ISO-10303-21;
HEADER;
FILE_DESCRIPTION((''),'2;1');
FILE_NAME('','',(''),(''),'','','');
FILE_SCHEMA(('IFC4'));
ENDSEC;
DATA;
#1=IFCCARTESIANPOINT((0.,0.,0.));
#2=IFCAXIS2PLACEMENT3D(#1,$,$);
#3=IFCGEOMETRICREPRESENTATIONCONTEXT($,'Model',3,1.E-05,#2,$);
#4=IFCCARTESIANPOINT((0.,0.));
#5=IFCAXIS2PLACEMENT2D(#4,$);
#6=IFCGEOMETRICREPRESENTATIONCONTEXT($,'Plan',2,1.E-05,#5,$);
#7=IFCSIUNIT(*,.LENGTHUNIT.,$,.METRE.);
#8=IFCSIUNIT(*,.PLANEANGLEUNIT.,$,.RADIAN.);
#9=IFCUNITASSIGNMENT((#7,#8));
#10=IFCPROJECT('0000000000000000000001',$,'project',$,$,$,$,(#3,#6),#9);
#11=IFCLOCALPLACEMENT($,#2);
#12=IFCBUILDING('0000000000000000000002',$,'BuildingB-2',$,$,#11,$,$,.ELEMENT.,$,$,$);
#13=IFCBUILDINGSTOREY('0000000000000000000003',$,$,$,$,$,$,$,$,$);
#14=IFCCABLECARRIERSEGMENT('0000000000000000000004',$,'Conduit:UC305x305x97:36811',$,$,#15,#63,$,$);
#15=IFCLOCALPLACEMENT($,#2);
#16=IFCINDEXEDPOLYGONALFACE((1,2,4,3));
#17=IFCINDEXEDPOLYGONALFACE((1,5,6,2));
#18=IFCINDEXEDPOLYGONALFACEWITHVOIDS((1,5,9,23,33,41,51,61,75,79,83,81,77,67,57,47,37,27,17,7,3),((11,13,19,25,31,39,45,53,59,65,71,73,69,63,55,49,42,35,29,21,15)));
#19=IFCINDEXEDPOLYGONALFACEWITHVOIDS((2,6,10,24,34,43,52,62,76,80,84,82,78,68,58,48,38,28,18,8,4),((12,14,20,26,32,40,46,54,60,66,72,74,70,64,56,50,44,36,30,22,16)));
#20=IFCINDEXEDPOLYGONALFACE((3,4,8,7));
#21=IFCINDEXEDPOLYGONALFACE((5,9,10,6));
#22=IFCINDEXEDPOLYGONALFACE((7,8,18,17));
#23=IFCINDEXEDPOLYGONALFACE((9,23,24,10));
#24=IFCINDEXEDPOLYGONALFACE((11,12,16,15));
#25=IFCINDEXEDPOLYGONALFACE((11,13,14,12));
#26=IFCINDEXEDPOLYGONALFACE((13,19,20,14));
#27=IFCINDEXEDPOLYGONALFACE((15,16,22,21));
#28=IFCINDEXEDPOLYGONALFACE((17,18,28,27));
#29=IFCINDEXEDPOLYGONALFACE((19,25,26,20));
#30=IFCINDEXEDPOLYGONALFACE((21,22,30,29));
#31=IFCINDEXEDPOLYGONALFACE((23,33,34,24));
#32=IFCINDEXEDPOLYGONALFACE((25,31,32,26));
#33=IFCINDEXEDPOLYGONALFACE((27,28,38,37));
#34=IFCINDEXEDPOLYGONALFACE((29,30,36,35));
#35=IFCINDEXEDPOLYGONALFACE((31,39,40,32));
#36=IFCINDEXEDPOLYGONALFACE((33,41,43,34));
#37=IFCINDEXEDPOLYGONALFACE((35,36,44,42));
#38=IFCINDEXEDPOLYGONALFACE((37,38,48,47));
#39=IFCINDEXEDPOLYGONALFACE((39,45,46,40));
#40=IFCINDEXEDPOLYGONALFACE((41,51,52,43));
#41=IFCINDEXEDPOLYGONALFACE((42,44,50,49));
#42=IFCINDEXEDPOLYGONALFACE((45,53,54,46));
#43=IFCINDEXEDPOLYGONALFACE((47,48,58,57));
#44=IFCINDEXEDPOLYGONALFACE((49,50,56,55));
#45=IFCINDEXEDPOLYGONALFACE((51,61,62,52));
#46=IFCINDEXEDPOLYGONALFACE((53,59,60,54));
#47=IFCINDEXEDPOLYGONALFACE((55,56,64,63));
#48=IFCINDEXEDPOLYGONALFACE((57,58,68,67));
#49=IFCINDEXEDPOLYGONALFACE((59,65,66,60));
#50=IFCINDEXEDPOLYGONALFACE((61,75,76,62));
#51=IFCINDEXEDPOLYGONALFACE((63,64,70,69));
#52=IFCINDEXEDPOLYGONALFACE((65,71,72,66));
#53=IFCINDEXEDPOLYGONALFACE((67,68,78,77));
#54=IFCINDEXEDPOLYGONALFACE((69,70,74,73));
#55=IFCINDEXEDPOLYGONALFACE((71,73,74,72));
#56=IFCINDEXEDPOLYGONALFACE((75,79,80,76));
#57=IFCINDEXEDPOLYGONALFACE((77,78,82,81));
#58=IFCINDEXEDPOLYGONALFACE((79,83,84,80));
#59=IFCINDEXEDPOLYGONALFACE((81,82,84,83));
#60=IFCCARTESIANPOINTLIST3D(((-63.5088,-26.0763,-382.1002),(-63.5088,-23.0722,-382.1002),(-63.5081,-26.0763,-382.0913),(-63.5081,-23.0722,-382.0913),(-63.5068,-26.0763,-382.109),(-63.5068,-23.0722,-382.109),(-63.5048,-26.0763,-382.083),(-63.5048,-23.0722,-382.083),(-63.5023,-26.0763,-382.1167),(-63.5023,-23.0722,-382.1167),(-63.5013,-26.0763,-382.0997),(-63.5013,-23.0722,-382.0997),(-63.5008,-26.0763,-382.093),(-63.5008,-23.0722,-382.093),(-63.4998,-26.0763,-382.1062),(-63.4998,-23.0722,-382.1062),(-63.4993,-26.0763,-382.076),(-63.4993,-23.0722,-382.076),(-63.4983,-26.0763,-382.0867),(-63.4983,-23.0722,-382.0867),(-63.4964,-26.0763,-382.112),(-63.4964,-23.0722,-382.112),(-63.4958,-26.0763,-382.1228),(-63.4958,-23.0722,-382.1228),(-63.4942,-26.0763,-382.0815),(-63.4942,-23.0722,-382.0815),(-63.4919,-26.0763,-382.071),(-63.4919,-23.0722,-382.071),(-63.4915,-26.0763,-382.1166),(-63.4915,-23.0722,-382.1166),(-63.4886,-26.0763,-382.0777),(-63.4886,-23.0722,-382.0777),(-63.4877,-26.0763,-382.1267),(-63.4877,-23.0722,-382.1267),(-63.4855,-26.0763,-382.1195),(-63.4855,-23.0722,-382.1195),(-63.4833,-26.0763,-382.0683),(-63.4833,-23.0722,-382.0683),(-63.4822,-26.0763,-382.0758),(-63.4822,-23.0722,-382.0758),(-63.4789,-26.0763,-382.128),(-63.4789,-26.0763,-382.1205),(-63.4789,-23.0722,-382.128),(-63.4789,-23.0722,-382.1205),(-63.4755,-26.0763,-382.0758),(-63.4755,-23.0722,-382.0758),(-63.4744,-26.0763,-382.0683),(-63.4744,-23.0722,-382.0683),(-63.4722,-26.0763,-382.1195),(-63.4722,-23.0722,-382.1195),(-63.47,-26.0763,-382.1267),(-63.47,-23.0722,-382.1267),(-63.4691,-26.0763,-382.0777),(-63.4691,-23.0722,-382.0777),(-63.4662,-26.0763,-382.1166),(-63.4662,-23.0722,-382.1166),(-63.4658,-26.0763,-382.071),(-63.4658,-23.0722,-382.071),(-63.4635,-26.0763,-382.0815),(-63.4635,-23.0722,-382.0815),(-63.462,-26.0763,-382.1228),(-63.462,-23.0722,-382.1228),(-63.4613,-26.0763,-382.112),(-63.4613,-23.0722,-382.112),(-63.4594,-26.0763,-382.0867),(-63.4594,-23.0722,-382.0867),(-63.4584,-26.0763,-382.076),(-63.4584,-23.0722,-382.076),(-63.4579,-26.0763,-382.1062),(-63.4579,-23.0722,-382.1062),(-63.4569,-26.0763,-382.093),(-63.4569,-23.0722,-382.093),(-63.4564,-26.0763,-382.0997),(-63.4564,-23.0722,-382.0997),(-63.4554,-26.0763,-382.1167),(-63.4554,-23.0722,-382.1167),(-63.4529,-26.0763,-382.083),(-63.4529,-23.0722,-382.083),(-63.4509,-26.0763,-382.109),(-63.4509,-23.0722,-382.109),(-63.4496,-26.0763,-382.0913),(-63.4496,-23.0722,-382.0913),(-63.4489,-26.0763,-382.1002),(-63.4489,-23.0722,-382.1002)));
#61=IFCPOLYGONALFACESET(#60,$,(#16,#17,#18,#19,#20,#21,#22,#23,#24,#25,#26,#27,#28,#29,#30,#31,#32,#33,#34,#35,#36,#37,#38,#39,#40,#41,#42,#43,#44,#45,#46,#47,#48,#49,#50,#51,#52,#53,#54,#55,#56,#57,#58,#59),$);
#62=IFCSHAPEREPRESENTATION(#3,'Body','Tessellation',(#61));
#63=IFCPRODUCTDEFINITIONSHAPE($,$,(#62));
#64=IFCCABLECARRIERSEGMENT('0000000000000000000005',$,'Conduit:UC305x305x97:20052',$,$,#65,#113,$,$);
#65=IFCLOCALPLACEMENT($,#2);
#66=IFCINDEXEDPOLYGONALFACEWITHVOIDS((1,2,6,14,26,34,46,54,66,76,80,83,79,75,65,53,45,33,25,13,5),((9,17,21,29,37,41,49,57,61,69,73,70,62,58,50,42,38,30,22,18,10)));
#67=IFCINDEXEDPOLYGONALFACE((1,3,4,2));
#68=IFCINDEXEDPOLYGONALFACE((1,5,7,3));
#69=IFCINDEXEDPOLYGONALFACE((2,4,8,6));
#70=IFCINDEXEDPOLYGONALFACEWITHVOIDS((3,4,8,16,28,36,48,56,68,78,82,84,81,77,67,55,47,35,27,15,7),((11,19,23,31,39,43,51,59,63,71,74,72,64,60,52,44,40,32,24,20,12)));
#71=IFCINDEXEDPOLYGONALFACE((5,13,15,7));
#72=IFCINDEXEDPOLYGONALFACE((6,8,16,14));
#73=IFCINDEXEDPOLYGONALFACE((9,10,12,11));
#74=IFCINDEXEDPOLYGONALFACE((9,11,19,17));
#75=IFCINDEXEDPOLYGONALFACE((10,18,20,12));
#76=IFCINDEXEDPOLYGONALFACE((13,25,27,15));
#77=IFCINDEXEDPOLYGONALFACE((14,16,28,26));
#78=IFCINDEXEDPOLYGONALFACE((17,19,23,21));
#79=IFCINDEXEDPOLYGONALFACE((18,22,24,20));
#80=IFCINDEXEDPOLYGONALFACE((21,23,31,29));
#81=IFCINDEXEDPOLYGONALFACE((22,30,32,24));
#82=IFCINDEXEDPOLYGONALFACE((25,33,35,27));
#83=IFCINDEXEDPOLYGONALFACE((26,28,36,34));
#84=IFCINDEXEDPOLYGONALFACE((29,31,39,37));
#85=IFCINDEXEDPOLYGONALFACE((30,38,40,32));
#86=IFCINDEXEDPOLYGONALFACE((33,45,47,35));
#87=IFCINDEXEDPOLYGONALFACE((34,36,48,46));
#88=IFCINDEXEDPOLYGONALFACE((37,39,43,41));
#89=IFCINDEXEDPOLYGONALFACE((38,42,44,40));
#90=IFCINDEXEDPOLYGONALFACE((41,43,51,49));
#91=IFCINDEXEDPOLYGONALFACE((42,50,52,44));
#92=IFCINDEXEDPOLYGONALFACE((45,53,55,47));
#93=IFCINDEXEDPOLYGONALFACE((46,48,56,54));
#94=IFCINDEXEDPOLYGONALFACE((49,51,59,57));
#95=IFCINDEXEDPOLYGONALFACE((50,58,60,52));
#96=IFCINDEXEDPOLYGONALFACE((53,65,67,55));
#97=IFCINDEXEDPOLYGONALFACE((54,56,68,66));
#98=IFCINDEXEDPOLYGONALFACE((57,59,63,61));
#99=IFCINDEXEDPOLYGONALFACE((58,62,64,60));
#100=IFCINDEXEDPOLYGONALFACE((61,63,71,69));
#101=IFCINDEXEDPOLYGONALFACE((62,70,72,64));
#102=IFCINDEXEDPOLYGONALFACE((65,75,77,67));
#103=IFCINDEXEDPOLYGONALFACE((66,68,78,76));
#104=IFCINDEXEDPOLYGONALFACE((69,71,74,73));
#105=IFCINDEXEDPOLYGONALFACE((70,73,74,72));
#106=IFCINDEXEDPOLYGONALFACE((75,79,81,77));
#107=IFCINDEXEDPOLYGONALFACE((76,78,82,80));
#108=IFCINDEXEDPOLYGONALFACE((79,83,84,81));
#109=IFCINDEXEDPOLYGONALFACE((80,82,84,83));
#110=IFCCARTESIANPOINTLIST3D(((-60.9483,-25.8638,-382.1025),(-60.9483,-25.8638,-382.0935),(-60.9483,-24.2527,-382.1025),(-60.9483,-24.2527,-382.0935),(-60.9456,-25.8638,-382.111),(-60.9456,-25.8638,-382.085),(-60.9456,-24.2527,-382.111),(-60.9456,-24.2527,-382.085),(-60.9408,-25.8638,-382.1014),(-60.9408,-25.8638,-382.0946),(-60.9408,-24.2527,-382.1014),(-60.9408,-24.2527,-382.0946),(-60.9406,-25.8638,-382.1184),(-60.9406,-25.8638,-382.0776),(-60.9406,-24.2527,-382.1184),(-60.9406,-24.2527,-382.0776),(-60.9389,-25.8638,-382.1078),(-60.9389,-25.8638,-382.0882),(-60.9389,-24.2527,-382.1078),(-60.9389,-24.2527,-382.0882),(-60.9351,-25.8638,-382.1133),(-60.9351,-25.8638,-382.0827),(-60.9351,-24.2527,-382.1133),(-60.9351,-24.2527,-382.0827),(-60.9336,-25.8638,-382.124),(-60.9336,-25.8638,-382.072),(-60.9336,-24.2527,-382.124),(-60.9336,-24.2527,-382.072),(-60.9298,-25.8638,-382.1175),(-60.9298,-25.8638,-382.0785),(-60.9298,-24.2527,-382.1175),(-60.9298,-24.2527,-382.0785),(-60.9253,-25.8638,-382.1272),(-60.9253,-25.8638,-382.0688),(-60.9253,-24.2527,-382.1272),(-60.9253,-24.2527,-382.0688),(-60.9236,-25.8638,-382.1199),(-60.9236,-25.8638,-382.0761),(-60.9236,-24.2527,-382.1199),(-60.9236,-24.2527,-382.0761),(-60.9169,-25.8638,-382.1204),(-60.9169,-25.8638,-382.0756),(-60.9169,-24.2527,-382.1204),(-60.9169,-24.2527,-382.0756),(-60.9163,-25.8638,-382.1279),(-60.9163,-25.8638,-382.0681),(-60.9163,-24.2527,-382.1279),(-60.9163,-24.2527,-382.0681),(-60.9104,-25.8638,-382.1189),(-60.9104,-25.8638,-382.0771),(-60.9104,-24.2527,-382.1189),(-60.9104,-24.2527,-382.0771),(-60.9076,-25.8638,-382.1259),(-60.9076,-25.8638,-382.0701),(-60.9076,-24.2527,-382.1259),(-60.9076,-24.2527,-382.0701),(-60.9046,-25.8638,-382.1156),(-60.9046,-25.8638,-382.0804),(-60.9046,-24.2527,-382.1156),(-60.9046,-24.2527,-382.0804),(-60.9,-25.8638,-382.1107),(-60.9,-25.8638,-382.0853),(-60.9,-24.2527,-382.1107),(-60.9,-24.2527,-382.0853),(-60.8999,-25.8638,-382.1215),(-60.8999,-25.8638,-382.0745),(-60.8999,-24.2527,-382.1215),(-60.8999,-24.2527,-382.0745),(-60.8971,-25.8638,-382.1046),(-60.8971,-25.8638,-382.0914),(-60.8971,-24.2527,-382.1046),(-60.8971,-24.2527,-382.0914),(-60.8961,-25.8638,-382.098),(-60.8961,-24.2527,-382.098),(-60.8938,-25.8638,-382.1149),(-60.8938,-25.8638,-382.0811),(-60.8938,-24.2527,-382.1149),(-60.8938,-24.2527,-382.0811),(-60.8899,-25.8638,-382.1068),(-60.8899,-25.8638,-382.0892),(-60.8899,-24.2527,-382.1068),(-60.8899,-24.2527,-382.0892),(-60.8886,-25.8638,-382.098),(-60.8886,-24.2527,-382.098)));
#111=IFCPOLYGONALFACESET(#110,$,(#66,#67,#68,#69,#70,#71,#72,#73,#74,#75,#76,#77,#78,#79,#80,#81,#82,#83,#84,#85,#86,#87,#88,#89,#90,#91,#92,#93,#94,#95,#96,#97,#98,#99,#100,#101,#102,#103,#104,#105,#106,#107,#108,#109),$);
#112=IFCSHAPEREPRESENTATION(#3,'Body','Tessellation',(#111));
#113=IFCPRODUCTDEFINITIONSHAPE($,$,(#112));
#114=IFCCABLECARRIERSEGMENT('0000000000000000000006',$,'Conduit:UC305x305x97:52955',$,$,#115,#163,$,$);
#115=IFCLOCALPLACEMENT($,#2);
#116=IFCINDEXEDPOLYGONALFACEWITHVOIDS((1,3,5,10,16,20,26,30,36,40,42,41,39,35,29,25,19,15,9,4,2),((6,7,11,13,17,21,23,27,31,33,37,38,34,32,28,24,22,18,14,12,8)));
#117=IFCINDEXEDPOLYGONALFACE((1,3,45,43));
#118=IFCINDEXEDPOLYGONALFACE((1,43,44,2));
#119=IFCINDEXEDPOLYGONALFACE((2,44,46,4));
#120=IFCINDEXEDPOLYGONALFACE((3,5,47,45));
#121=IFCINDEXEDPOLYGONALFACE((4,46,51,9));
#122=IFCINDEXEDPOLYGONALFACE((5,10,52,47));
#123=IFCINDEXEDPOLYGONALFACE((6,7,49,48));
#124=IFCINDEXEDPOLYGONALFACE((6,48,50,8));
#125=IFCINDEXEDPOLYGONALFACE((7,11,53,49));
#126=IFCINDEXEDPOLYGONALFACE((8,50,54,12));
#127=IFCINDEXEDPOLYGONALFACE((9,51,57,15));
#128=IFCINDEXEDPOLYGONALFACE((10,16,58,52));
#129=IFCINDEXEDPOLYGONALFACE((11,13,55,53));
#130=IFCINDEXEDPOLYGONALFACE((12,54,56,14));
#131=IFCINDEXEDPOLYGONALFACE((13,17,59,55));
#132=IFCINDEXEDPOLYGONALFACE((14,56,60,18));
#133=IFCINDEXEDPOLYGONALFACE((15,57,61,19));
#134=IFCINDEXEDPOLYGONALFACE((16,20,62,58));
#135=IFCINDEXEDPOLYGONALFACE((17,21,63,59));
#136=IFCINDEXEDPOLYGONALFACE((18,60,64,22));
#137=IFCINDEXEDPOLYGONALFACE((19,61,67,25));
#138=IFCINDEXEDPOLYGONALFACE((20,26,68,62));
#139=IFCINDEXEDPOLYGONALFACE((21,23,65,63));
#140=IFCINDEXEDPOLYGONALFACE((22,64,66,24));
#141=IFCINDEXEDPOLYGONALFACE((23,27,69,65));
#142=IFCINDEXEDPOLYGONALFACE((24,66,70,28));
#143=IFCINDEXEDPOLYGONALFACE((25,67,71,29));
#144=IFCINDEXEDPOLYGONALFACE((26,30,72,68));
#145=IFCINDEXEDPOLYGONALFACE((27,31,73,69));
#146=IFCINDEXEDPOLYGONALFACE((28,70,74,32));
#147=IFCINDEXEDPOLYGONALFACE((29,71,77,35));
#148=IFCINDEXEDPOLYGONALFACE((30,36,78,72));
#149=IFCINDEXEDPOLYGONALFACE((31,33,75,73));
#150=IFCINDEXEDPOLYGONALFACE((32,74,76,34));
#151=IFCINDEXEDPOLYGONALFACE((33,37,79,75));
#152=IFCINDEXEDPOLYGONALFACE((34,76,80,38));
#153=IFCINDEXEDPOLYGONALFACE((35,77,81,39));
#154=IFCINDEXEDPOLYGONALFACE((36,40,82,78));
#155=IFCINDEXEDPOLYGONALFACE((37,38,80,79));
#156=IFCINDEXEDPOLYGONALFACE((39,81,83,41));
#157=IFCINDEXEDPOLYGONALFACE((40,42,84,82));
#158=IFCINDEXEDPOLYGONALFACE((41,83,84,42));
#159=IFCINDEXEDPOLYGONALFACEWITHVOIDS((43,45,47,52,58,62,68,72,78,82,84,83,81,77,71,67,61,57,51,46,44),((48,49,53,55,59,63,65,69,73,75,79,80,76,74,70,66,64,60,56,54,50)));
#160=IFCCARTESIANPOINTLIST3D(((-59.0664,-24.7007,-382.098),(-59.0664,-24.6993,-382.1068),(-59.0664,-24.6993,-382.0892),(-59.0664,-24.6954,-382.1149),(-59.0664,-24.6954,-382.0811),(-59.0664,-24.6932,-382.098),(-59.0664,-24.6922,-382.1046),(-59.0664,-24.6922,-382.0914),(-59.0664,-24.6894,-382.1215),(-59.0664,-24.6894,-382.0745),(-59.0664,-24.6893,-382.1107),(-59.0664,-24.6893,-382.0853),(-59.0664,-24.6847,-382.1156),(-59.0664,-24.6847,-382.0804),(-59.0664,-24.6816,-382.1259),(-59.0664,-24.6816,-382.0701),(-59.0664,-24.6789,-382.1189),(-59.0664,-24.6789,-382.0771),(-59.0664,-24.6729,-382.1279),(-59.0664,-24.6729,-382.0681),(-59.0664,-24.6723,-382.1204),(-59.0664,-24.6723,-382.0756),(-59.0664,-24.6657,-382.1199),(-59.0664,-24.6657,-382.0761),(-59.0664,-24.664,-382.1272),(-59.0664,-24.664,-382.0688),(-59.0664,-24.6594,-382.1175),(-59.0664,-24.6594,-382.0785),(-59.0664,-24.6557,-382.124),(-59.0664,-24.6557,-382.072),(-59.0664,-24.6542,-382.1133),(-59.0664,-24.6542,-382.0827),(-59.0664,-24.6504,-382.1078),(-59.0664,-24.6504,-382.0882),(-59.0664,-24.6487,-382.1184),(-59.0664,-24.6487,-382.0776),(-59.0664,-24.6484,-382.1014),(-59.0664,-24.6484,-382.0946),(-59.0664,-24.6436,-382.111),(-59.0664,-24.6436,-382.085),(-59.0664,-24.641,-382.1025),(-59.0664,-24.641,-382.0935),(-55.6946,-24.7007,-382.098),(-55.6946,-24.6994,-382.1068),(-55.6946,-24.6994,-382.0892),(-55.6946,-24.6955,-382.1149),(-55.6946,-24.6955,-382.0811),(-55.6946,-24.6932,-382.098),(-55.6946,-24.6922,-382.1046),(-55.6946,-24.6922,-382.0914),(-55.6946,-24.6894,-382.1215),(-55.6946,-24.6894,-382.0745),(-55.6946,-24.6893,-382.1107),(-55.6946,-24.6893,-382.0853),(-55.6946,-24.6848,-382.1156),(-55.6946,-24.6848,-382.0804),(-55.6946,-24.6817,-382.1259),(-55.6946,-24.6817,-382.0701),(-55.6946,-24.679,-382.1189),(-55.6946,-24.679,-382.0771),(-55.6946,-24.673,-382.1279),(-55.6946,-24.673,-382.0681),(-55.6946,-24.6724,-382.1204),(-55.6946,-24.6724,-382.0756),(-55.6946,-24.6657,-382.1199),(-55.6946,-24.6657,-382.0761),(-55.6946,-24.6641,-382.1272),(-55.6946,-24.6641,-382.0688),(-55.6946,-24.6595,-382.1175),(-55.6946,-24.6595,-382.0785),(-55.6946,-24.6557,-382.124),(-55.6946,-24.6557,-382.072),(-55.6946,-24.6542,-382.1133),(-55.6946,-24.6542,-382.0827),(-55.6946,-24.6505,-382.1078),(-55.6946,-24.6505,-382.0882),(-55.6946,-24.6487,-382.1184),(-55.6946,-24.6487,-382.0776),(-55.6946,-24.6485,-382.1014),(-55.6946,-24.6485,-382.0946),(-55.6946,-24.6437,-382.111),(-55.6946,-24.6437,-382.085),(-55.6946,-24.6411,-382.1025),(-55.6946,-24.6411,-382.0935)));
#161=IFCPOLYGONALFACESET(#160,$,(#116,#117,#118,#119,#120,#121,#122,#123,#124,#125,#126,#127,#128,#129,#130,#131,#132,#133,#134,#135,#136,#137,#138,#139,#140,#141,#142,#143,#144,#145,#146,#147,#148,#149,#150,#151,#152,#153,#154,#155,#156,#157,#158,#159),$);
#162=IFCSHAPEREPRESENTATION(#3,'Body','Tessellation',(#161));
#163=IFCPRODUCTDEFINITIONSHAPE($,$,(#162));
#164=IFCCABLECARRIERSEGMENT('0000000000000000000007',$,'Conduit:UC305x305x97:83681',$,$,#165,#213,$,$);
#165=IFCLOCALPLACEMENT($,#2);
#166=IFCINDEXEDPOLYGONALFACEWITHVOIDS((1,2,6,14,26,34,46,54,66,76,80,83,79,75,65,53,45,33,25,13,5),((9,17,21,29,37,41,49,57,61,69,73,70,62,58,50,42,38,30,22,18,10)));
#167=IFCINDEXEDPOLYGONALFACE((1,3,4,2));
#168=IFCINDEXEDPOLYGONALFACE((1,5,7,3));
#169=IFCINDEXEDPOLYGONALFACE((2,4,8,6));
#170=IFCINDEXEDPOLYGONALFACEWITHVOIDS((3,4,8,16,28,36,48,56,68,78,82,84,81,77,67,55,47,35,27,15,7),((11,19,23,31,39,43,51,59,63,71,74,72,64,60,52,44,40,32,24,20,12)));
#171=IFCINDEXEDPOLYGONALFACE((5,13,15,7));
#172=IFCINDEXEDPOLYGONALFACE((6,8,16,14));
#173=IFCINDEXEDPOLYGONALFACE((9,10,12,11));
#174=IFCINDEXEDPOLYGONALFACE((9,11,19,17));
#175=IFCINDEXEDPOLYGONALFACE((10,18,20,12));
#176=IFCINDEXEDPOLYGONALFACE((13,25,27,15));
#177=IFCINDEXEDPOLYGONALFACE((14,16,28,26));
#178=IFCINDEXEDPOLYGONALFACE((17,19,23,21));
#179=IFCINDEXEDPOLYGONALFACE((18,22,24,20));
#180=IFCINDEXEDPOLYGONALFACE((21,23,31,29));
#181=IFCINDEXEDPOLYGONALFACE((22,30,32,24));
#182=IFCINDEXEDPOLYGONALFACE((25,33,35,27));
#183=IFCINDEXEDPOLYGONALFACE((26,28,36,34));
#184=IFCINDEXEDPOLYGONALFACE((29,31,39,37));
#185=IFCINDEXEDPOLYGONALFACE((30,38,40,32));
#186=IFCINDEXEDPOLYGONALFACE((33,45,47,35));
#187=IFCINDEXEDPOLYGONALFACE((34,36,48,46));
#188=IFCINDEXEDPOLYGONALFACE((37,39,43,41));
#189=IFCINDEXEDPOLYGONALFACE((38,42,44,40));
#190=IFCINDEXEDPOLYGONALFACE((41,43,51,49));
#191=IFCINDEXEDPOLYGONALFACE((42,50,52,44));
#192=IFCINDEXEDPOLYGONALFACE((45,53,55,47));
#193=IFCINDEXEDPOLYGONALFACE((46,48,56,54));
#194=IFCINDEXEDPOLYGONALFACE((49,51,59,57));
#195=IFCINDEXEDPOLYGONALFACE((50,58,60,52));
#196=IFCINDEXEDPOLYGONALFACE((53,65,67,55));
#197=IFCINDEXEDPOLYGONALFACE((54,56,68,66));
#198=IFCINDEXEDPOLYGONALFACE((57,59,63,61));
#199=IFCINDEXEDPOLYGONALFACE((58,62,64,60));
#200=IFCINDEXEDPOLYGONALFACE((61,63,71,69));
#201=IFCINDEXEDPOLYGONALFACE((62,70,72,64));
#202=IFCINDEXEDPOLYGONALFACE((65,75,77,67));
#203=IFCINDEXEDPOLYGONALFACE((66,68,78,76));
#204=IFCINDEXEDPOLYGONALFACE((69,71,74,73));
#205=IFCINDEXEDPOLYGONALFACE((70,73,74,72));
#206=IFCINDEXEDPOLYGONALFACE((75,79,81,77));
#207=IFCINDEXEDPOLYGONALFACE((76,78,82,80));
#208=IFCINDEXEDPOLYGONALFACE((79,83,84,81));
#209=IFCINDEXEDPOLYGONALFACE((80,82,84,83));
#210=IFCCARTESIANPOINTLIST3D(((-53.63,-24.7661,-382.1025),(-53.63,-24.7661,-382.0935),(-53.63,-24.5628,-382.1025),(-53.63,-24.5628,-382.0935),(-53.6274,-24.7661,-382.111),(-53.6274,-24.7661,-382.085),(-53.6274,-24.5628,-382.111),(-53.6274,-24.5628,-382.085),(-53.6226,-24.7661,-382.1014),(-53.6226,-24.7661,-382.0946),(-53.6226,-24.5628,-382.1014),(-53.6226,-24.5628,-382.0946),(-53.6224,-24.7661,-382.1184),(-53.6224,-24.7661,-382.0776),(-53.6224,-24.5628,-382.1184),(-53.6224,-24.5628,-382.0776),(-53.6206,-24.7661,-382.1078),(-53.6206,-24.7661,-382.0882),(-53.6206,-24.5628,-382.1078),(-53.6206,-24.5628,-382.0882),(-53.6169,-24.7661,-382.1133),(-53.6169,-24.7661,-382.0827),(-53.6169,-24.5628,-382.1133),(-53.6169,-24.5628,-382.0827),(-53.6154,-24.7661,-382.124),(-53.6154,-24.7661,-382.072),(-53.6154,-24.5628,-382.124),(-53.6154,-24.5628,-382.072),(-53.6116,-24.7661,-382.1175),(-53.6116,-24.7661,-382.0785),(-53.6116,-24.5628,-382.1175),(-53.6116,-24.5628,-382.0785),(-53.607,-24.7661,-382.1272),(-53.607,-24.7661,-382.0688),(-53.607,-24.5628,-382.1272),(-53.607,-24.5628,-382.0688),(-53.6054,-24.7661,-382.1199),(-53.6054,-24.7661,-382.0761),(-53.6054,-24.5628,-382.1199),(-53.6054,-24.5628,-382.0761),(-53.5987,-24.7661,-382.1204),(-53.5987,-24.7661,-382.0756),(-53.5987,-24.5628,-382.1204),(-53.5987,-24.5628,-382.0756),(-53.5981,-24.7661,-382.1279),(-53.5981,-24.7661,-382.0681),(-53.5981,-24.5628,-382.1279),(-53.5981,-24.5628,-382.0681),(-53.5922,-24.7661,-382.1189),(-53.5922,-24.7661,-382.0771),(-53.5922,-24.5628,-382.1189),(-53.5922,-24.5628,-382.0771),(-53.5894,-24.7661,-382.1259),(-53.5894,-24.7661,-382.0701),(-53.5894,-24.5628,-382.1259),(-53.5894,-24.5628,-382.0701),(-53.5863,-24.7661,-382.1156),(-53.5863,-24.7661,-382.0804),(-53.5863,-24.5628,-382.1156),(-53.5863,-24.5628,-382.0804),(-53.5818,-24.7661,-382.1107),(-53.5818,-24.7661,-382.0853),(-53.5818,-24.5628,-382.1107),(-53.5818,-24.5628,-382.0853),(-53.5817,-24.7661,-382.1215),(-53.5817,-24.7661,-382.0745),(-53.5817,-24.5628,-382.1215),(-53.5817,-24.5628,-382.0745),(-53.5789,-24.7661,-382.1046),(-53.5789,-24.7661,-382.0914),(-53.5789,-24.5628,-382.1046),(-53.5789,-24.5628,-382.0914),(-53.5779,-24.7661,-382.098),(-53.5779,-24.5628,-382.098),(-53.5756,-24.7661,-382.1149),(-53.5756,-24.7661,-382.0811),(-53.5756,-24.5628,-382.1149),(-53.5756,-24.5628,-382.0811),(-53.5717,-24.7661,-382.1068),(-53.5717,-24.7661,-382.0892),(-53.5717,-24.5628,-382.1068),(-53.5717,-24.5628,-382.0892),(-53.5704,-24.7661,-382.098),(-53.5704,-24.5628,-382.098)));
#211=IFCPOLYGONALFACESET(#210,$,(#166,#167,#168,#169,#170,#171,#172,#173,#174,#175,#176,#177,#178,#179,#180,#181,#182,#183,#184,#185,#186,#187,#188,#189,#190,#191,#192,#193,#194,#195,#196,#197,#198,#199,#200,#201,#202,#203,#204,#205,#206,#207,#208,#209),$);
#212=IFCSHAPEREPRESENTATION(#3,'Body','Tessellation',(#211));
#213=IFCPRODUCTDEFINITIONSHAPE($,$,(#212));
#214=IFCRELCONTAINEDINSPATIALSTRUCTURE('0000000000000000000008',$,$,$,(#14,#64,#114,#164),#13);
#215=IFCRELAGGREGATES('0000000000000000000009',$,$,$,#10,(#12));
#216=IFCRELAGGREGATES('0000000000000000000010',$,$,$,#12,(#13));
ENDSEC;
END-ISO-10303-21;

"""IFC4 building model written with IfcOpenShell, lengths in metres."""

from ifc_helpers import new_model, entity, si_unit, origin, origin_2d, place, context, project, spatial, element, save


model = new_model("IFC4")

# Units and contexts
model_context = context("Model", 3, precision=1e-05, world=origin())
plan_context = context("Plan", 2, precision=1e-05, world=origin_2d())
ifc_project = project(units=[si_unit("LENGTHUNIT", "METRE"), si_unit("PLANEANGLEUNIT", "RADIAN")], contexts=[model_context, plan_context])

# Building, storey
building_placement = place(None, origin())
building = spatial("IfcBuilding", under=ifc_project, at=building_placement, Name="BuildingB-2", CompositionType="ELEMENT")
storey = spatial("IfcBuildingStorey", under=building)

# Cable carrier segments
element("IfcCableCarrierSegment", 1, inside=storey, Name="Conduit:UC305x305x97:36811", context=model_context, shape_type="AdvancedSweptSolid", body=[
    entity("IfcSweptDiskSolid", entity("IfcCompositeCurve", [entity("IfcCompositeCurveSegment", "CONTINUOUS", False, entity("IfcPolyline", [entity("IfcCartesianPoint", [63.4789, 26.0763, 382.098]), entity("IfcCartesianPoint", [63.4789, 23.0722, 382.098])]))], False), 0.03, 0.0225),
])
element("IfcCableCarrierSegment", 2, inside=storey, Name="Conduit:UC305x305x97:20052", context=model_context, shape_type="AdvancedSweptSolid", body=[
    entity("IfcSweptDiskSolid", entity("IfcCompositeCurve", [entity("IfcCompositeCurveSegment", "CONTINUOUS", False, entity("IfcPolyline", [entity("IfcCartesianPoint", [60.9186, 24.2527, 382.098]), entity("IfcCartesianPoint", [60.9186, 25.8638, 382.098])]))], False), 0.03, 0.0225),
])
element("IfcCableCarrierSegment", 3, inside=storey, Name="Conduit:UC305x305x97:52955", context=model_context, shape_type="AdvancedSweptSolid", body=[
    entity("IfcSweptDiskSolid", entity("IfcCompositeCurve", [entity("IfcCompositeCurveSegment", "CONTINUOUS", False, entity("IfcPolyline", [entity("IfcCartesianPoint", [59.0664, 24.6707, 382.098]), entity("IfcCartesianPoint", [55.6946, 24.6707, 382.098])]))], False), 0.03, 0.0225),
])
element("IfcCableCarrierSegment", 4, inside=storey, Name="Conduit:UC305x305x97:83681", context=model_context, shape_type="AdvancedSweptSolid", body=[
    entity("IfcSweptDiskSolid", entity("IfcCompositeCurve", [entity("IfcCompositeCurveSegment", "CONTINUOUS", False, entity("IfcPolyline", [entity("IfcCartesianPoint", [53.6004, 24.5628, 382.098]), entity("IfcCartesianPoint", [53.6004, 24.7661, 382.098])]))], False), 0.03, 0.0225),
])

save(model, "model.ifc")
